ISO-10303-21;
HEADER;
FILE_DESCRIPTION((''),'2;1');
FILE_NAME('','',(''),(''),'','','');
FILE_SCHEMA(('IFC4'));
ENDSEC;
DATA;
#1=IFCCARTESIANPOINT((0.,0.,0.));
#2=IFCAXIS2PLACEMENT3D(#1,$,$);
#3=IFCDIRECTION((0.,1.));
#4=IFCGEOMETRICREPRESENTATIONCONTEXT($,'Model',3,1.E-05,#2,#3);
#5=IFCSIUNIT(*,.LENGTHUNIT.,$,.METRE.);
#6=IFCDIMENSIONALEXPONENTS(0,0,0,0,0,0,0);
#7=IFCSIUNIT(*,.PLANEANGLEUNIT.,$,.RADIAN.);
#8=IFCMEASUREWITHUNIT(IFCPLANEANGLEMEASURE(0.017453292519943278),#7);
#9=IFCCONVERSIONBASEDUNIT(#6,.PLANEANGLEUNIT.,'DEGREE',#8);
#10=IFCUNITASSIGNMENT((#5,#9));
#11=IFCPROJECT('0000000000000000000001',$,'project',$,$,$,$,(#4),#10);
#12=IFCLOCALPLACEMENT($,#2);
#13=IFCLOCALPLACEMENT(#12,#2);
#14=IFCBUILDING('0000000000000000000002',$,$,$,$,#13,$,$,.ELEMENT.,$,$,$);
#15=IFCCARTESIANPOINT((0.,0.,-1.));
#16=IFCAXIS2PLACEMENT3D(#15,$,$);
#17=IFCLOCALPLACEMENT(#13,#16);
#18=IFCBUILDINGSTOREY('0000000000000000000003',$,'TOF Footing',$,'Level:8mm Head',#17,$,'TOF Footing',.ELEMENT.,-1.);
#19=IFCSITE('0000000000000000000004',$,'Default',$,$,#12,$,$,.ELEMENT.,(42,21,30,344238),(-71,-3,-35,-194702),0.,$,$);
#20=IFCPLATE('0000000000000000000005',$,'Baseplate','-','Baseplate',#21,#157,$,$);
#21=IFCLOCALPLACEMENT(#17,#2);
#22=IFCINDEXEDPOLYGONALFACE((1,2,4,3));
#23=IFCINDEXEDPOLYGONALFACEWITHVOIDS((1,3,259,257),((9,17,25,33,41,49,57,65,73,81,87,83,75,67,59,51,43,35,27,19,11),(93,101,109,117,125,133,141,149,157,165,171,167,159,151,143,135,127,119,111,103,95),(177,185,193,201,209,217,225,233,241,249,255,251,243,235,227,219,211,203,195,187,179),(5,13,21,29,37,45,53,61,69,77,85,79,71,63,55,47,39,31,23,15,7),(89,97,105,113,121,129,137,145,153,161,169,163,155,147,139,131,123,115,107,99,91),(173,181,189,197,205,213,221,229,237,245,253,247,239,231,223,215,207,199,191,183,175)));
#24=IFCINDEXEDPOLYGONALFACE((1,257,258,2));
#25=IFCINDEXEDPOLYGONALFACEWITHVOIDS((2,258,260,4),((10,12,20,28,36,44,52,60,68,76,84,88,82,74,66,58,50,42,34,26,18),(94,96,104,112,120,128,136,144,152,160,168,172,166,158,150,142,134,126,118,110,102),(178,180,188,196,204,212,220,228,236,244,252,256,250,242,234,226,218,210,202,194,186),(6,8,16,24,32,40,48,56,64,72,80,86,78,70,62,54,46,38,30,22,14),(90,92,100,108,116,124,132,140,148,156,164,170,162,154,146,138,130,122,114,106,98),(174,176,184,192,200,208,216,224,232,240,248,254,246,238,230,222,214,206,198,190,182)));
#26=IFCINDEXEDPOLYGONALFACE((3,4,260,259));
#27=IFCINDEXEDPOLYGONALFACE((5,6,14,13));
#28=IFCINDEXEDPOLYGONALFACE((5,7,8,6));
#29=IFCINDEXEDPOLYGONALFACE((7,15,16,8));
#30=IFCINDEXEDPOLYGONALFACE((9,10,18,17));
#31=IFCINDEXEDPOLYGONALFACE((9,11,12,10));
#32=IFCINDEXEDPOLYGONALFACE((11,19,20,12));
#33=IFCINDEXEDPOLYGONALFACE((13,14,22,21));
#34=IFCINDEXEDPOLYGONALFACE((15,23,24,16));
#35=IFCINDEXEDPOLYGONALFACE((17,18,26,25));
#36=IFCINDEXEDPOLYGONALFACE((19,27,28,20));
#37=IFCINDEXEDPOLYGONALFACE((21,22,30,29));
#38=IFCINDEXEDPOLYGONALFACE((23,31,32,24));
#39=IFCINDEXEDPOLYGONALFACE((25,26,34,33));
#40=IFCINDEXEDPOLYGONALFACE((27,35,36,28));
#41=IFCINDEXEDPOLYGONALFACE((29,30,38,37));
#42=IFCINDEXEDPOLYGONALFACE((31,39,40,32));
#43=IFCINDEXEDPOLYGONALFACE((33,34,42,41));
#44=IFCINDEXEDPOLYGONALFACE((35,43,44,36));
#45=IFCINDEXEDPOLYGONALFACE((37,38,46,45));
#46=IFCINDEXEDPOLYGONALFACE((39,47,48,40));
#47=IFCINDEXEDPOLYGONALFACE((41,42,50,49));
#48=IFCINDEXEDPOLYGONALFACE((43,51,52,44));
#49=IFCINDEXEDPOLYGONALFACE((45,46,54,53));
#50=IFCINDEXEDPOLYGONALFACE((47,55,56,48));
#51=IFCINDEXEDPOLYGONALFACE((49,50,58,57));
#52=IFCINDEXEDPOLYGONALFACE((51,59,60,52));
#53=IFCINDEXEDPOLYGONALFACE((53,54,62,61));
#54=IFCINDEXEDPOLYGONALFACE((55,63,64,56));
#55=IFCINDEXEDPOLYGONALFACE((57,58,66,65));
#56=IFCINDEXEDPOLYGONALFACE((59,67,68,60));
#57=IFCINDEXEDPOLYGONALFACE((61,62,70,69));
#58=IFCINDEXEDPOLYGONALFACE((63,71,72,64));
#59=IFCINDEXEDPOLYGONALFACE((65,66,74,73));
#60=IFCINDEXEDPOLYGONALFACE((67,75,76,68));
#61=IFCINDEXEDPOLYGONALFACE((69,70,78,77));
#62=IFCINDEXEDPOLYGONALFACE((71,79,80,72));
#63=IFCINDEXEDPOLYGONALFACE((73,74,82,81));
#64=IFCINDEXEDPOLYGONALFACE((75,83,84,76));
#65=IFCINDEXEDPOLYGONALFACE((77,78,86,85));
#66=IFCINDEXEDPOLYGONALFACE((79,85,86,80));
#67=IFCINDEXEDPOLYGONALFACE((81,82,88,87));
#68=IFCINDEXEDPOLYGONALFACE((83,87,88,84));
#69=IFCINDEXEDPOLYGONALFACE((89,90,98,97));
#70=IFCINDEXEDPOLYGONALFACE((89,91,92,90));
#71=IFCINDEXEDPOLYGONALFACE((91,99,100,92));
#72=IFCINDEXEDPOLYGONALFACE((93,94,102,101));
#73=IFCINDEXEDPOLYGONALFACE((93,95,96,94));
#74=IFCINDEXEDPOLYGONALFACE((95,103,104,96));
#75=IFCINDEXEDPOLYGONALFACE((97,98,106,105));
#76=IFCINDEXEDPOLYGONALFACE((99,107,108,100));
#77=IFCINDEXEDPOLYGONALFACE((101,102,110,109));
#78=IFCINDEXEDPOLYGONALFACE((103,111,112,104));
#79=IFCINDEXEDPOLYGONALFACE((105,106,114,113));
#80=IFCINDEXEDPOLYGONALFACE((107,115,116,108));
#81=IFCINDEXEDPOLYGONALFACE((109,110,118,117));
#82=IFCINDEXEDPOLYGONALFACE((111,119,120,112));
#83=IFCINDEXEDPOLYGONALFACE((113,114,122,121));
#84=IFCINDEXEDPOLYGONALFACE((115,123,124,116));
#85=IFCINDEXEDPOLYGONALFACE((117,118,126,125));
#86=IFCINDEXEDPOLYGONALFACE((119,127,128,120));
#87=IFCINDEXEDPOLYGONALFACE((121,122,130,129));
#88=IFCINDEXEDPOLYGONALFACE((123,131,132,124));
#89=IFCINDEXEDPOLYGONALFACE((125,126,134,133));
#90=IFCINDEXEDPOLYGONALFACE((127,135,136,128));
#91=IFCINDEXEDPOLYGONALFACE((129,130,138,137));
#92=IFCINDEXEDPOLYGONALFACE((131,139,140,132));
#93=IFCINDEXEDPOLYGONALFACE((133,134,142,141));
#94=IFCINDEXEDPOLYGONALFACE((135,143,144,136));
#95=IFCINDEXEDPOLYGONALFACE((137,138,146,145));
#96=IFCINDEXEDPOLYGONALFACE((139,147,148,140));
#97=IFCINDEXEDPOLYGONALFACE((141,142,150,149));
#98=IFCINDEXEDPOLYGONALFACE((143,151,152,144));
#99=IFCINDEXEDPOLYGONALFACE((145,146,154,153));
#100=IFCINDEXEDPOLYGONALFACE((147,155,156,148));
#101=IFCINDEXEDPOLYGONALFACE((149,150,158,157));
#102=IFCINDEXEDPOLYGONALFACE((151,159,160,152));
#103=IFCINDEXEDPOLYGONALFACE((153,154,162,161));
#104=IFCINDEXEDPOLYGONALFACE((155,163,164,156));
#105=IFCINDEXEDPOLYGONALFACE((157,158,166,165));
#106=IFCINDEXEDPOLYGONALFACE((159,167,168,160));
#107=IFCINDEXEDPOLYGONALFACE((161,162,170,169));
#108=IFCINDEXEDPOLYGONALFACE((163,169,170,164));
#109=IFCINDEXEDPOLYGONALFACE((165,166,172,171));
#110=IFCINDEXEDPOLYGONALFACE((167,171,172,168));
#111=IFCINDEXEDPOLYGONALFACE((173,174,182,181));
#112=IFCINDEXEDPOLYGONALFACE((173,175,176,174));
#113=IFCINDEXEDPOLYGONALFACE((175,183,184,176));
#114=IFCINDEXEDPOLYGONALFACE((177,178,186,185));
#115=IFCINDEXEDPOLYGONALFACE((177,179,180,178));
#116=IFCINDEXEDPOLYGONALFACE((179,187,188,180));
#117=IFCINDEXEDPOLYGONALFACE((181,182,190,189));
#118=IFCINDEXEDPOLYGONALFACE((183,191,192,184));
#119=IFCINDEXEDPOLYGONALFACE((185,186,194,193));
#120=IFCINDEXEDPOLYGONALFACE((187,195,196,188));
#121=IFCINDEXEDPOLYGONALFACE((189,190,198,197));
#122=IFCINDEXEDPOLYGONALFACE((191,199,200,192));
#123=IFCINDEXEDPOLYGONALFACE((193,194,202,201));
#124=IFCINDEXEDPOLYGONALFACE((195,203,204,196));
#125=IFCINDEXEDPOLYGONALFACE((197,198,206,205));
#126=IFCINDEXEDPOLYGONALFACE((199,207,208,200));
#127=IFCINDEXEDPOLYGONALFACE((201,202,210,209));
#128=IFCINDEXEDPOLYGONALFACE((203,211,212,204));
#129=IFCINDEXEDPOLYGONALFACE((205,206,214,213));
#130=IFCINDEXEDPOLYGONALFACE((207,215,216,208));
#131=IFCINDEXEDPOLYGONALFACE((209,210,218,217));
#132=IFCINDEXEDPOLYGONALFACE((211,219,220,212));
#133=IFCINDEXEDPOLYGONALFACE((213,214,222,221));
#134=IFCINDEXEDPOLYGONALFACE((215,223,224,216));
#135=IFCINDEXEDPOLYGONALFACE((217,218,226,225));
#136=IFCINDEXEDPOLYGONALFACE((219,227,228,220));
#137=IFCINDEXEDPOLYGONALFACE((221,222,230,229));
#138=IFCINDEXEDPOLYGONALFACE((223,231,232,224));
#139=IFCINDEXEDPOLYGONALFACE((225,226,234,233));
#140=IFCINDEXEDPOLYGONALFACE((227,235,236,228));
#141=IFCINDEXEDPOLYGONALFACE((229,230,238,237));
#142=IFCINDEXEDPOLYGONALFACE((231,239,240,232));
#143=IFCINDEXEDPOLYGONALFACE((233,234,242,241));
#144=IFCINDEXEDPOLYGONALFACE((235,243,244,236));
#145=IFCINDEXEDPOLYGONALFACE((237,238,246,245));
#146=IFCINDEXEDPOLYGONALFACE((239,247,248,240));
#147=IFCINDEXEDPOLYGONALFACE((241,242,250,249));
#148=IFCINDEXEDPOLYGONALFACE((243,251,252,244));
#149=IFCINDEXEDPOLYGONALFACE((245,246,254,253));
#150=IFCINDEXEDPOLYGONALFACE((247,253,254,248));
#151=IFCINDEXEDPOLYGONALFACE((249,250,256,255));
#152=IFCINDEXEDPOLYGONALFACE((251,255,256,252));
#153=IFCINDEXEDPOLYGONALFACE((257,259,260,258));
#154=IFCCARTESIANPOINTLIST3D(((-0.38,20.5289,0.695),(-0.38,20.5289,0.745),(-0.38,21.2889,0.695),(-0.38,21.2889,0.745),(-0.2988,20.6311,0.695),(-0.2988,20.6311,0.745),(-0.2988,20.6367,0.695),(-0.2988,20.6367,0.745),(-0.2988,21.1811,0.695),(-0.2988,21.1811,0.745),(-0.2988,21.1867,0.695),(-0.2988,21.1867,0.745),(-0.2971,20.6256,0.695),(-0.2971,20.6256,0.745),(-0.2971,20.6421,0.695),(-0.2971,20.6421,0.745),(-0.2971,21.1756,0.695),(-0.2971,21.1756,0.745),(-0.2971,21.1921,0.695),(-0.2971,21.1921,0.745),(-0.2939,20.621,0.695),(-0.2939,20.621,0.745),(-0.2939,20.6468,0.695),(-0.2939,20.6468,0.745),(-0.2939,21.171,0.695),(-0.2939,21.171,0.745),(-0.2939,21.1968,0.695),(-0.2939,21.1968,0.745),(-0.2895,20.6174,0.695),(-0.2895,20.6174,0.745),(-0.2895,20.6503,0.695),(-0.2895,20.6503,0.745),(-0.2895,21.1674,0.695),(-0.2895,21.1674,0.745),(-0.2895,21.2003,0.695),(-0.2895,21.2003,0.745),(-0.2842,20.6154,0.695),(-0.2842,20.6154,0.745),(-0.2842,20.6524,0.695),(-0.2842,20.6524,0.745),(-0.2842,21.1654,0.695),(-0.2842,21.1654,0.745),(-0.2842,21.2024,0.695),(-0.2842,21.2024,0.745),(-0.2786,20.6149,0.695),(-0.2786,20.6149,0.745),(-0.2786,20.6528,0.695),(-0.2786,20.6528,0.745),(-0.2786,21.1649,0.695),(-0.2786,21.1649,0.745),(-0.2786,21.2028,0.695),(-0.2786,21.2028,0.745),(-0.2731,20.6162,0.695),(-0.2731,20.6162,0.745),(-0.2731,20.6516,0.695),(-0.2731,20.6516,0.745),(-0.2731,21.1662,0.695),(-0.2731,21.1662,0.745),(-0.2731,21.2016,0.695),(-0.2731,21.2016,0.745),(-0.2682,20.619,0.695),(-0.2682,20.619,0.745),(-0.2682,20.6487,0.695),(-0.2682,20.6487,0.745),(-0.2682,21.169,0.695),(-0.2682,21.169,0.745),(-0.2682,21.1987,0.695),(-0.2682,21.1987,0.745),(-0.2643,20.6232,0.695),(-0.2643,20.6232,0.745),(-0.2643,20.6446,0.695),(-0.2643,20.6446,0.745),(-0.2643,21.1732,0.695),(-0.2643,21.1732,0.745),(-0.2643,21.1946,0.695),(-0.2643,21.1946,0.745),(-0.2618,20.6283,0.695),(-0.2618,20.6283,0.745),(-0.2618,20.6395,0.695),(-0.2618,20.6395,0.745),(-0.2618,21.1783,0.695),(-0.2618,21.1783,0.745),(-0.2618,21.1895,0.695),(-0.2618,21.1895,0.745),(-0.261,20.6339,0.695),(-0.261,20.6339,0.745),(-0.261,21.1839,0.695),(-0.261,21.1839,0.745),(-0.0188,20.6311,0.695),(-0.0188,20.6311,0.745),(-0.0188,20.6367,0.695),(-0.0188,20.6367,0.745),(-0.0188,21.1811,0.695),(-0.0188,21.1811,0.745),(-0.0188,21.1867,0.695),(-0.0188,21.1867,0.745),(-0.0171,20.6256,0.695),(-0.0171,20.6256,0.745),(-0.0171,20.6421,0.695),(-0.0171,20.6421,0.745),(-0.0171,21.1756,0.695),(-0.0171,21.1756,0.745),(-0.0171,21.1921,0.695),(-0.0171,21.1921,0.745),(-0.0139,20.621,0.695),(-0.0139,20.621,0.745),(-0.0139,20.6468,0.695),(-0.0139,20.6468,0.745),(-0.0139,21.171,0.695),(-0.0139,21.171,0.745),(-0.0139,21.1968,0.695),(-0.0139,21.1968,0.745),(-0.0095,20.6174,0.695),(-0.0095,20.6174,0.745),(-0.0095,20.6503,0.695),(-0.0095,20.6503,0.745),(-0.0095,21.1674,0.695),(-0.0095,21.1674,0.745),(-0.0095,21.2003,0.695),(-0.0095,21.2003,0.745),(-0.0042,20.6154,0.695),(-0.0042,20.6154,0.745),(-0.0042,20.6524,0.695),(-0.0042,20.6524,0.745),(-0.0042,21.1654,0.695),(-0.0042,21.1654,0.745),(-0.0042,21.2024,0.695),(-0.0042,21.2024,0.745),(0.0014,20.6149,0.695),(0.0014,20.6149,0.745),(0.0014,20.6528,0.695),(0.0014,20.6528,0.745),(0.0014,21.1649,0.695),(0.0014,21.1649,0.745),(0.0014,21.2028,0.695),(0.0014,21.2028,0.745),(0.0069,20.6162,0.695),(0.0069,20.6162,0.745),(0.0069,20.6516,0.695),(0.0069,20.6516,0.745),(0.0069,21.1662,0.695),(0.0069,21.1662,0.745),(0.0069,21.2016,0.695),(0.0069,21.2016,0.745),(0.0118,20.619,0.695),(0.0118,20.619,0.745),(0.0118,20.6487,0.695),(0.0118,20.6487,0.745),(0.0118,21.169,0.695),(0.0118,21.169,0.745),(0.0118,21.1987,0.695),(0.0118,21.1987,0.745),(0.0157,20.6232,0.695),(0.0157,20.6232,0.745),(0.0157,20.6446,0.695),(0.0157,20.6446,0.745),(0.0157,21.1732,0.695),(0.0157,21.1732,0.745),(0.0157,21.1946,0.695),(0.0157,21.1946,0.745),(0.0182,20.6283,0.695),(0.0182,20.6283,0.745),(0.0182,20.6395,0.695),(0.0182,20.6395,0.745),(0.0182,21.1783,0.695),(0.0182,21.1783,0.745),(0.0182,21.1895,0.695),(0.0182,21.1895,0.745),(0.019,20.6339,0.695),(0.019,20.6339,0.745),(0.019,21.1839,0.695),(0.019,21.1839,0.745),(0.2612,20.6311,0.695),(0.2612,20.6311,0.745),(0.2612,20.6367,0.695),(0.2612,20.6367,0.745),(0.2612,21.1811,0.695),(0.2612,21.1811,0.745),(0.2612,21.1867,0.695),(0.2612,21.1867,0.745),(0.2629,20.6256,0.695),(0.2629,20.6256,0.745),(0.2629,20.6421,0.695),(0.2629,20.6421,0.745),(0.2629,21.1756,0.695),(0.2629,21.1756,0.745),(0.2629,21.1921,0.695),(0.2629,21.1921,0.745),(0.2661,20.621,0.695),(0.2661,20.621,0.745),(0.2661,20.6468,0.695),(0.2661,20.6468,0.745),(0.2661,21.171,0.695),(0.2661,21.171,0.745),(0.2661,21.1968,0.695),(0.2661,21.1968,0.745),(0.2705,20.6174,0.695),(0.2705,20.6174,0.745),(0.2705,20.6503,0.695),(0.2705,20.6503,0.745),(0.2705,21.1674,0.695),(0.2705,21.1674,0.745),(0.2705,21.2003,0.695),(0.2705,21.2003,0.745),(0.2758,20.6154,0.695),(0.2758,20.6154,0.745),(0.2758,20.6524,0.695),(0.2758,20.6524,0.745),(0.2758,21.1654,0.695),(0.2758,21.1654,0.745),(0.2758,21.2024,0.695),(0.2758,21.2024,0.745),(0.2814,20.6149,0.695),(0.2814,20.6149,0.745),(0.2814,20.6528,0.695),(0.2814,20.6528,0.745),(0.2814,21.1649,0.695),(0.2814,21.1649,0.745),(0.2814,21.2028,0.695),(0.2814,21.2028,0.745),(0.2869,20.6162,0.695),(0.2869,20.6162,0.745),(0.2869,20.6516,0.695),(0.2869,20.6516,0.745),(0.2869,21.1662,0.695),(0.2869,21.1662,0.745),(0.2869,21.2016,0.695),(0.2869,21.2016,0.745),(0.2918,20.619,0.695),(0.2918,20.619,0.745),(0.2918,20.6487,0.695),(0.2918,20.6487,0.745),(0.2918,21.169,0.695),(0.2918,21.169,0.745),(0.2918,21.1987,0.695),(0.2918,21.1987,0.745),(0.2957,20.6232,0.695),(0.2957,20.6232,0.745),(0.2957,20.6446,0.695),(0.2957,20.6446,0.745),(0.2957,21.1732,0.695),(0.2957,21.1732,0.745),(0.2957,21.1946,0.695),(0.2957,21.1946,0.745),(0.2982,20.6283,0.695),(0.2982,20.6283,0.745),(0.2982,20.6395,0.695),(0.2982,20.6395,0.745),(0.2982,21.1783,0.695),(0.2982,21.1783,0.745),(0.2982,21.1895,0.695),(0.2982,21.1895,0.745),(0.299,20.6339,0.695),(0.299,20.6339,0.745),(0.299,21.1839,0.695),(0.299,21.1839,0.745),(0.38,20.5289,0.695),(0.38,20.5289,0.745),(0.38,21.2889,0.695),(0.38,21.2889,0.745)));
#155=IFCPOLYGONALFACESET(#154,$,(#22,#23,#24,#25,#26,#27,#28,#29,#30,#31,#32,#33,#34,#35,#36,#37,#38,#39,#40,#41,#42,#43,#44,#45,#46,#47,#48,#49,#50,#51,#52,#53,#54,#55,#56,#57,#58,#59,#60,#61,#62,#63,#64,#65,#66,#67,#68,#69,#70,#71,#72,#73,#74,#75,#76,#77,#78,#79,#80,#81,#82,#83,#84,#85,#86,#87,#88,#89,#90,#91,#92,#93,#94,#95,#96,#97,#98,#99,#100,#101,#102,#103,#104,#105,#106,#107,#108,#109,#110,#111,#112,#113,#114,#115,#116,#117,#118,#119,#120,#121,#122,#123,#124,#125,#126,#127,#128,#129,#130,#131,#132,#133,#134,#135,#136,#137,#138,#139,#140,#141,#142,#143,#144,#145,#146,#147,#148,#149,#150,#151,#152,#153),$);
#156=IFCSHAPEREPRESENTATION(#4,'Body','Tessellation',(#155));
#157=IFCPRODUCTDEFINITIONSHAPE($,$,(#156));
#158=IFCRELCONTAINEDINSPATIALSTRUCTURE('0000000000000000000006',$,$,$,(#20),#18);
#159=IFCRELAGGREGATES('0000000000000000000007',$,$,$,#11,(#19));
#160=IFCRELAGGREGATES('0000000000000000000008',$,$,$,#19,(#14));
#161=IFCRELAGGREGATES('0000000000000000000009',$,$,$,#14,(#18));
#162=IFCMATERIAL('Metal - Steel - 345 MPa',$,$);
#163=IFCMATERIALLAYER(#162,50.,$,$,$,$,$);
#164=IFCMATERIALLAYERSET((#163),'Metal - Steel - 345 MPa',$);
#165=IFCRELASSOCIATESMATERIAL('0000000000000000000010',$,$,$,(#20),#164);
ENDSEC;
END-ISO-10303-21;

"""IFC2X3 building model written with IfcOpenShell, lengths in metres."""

from ifc_helpers import new_model, entity, si_unit, converted_unit, direction, frame, frame_2d, origin, origin_with_axes, place, context, project, spatial, polyline, circle, outline, extrude, material, layer, layer_set, element, save


model = new_model("IFC2X3")

# Units and contexts
model_context = context("Model", 3, precision=1e-05, world=origin(), true_north=direction((0.0, 1.0)))
ifc_project = project(units=[si_unit("LENGTHUNIT", "METRE"), converted_unit("PLANEANGLEUNIT", "DEGREE", entity("IfcPlaneAngleMeasure", 0.017453292519943278), si_unit("PLANEANGLEUNIT", "RADIAN"), dimensions=[0, 0, 0, 0, 0, 0, 0])], contexts=[model_context])

# Site, building, storey
site_placement = place(None, origin())
site = spatial("IfcSite", under=ifc_project, at=site_placement, Name="Default", CompositionType="ELEMENT", RefLatitude=(42, 21, 30, 344238), RefLongitude=(-71, -3, -35, -194702), RefElevation=0.0)
building_placement = place(site_placement, origin())
building = spatial("IfcBuilding", under=site, at=building_placement, CompositionType="ELEMENT")
storey_placement = place(building_placement, frame((0.0, 0.0, -1.0)))
storey = spatial("IfcBuildingStorey", under=building, at=storey_placement, Name="TOF Footing", ObjectType="Level:8mm Head", LongName="TOF Footing", CompositionType="ELEMENT", Elevation=-1.0)

# Plate, openings
ifc_material_1 = material(Name="Metal - Steel - 345 MPa")
ifc_layer = layer(ifc_material_1, 50.0)
ifc_layer_set = layer_set([ifc_layer], Name="Metal - Steel - 345 MPa")
plate_1_placement = place(storey_placement, frame((-0.38, 21.2889, 0.745), z_axis=(0.0, 0.0, -1.0), x_axis=(1.0, 0.0, 0.0)))
plate_1 = element("IfcPlate", 1, at=plate_1_placement, inside=storey, material=ifc_layer_set, Name="Baseplate", Description="-", ObjectType="Baseplate", context=model_context, shape_type="SweptSolid", body=[
    extrude(outline(polyline([(0.0, 0.0), (0.76, 0.0), (0.76, 0.76), (0.0, 0.76), (0.0, 0.0)])), origin_with_axes(), (0.0, 0.0, 1.0), 0.05),
])
opening_1_placement = place(plate_1_placement, frame((0.38, 0.38, 0.0505), z_axis=(0.0, 0.0, -1.0), x_axis=(1.0, 0.0, 0.0)))
element("IfcOpeningElement", 2, at=opening_1_placement, cuts=plate_1, ObjectType="Opening", context=model_context, shape_type="SweptSolid", body=[
    extrude(circle(Radius=0.019, at=frame_2d((0.0, 0.275), x_axis=(1.0, 0.0))), origin(), (0.0, 0.0, 1.0), 0.051),
])
opening_2_placement = place(plate_1_placement, frame((0.38, 0.38, 0.0505), z_axis=(0.0, 0.0, -1.0), x_axis=(1.0, 0.0, 0.0)))
element("IfcOpeningElement", 3, at=opening_2_placement, cuts=plate_1, ObjectType="Opening", context=model_context, shape_type="SweptSolid", body=[
    extrude(circle(Radius=0.019, at=frame_2d((0.28, 0.275), x_axis=(1.0, 0.0))), origin(), (0.0, 0.0, 1.0), 0.051),
])
opening_3_placement = place(plate_1_placement, frame((0.38, 0.38, 0.0505), z_axis=(0.0, 0.0, -1.0), x_axis=(1.0, 0.0, 0.0)))
element("IfcOpeningElement", 4, at=opening_3_placement, cuts=plate_1, ObjectType="Opening", context=model_context, shape_type="SweptSolid", body=[
    extrude(circle(Radius=0.019, at=frame_2d((-0.28, 0.275), x_axis=(1.0, 0.0))), origin(), (0.0, 0.0, 1.0), 0.051),
])
opening_4_placement = place(plate_1_placement, frame((0.38, 0.38, 0.0505), z_axis=(0.0, 0.0, -1.0), x_axis=(1.0, 0.0, 0.0)))
element("IfcOpeningElement", 5, at=opening_4_placement, cuts=plate_1, ObjectType="Opening", context=model_context, shape_type="SweptSolid", body=[
    extrude(circle(Radius=0.019, at=frame_2d((0.0, -0.275), x_axis=(1.0, 0.0))), origin(), (0.0, 0.0, 1.0), 0.051),
])
opening_5_placement = place(plate_1_placement, frame((0.38, 0.38, 0.0505), z_axis=(0.0, 0.0, -1.0), x_axis=(1.0, 0.0, 0.0)))
element("IfcOpeningElement", 6, at=opening_5_placement, cuts=plate_1, ObjectType="Opening", context=model_context, shape_type="SweptSolid", body=[
    extrude(circle(Radius=0.019, at=frame_2d((0.28, -0.275), x_axis=(1.0, 0.0))), origin(), (0.0, 0.0, 1.0), 0.051),
])
opening_6_placement = place(plate_1_placement, frame((0.38, 0.38, 0.0505), z_axis=(0.0, 0.0, -1.0), x_axis=(1.0, 0.0, 0.0)))
element("IfcOpeningElement", 7, at=opening_6_placement, cuts=plate_1, ObjectType="Opening", context=model_context, shape_type="SweptSolid", body=[
    extrude(circle(Radius=0.019, at=frame_2d((-0.28, -0.275), x_axis=(1.0, 0.0))), origin(), (0.0, 0.0, 1.0), 0.051),
])

save(model, "model.ifc")
